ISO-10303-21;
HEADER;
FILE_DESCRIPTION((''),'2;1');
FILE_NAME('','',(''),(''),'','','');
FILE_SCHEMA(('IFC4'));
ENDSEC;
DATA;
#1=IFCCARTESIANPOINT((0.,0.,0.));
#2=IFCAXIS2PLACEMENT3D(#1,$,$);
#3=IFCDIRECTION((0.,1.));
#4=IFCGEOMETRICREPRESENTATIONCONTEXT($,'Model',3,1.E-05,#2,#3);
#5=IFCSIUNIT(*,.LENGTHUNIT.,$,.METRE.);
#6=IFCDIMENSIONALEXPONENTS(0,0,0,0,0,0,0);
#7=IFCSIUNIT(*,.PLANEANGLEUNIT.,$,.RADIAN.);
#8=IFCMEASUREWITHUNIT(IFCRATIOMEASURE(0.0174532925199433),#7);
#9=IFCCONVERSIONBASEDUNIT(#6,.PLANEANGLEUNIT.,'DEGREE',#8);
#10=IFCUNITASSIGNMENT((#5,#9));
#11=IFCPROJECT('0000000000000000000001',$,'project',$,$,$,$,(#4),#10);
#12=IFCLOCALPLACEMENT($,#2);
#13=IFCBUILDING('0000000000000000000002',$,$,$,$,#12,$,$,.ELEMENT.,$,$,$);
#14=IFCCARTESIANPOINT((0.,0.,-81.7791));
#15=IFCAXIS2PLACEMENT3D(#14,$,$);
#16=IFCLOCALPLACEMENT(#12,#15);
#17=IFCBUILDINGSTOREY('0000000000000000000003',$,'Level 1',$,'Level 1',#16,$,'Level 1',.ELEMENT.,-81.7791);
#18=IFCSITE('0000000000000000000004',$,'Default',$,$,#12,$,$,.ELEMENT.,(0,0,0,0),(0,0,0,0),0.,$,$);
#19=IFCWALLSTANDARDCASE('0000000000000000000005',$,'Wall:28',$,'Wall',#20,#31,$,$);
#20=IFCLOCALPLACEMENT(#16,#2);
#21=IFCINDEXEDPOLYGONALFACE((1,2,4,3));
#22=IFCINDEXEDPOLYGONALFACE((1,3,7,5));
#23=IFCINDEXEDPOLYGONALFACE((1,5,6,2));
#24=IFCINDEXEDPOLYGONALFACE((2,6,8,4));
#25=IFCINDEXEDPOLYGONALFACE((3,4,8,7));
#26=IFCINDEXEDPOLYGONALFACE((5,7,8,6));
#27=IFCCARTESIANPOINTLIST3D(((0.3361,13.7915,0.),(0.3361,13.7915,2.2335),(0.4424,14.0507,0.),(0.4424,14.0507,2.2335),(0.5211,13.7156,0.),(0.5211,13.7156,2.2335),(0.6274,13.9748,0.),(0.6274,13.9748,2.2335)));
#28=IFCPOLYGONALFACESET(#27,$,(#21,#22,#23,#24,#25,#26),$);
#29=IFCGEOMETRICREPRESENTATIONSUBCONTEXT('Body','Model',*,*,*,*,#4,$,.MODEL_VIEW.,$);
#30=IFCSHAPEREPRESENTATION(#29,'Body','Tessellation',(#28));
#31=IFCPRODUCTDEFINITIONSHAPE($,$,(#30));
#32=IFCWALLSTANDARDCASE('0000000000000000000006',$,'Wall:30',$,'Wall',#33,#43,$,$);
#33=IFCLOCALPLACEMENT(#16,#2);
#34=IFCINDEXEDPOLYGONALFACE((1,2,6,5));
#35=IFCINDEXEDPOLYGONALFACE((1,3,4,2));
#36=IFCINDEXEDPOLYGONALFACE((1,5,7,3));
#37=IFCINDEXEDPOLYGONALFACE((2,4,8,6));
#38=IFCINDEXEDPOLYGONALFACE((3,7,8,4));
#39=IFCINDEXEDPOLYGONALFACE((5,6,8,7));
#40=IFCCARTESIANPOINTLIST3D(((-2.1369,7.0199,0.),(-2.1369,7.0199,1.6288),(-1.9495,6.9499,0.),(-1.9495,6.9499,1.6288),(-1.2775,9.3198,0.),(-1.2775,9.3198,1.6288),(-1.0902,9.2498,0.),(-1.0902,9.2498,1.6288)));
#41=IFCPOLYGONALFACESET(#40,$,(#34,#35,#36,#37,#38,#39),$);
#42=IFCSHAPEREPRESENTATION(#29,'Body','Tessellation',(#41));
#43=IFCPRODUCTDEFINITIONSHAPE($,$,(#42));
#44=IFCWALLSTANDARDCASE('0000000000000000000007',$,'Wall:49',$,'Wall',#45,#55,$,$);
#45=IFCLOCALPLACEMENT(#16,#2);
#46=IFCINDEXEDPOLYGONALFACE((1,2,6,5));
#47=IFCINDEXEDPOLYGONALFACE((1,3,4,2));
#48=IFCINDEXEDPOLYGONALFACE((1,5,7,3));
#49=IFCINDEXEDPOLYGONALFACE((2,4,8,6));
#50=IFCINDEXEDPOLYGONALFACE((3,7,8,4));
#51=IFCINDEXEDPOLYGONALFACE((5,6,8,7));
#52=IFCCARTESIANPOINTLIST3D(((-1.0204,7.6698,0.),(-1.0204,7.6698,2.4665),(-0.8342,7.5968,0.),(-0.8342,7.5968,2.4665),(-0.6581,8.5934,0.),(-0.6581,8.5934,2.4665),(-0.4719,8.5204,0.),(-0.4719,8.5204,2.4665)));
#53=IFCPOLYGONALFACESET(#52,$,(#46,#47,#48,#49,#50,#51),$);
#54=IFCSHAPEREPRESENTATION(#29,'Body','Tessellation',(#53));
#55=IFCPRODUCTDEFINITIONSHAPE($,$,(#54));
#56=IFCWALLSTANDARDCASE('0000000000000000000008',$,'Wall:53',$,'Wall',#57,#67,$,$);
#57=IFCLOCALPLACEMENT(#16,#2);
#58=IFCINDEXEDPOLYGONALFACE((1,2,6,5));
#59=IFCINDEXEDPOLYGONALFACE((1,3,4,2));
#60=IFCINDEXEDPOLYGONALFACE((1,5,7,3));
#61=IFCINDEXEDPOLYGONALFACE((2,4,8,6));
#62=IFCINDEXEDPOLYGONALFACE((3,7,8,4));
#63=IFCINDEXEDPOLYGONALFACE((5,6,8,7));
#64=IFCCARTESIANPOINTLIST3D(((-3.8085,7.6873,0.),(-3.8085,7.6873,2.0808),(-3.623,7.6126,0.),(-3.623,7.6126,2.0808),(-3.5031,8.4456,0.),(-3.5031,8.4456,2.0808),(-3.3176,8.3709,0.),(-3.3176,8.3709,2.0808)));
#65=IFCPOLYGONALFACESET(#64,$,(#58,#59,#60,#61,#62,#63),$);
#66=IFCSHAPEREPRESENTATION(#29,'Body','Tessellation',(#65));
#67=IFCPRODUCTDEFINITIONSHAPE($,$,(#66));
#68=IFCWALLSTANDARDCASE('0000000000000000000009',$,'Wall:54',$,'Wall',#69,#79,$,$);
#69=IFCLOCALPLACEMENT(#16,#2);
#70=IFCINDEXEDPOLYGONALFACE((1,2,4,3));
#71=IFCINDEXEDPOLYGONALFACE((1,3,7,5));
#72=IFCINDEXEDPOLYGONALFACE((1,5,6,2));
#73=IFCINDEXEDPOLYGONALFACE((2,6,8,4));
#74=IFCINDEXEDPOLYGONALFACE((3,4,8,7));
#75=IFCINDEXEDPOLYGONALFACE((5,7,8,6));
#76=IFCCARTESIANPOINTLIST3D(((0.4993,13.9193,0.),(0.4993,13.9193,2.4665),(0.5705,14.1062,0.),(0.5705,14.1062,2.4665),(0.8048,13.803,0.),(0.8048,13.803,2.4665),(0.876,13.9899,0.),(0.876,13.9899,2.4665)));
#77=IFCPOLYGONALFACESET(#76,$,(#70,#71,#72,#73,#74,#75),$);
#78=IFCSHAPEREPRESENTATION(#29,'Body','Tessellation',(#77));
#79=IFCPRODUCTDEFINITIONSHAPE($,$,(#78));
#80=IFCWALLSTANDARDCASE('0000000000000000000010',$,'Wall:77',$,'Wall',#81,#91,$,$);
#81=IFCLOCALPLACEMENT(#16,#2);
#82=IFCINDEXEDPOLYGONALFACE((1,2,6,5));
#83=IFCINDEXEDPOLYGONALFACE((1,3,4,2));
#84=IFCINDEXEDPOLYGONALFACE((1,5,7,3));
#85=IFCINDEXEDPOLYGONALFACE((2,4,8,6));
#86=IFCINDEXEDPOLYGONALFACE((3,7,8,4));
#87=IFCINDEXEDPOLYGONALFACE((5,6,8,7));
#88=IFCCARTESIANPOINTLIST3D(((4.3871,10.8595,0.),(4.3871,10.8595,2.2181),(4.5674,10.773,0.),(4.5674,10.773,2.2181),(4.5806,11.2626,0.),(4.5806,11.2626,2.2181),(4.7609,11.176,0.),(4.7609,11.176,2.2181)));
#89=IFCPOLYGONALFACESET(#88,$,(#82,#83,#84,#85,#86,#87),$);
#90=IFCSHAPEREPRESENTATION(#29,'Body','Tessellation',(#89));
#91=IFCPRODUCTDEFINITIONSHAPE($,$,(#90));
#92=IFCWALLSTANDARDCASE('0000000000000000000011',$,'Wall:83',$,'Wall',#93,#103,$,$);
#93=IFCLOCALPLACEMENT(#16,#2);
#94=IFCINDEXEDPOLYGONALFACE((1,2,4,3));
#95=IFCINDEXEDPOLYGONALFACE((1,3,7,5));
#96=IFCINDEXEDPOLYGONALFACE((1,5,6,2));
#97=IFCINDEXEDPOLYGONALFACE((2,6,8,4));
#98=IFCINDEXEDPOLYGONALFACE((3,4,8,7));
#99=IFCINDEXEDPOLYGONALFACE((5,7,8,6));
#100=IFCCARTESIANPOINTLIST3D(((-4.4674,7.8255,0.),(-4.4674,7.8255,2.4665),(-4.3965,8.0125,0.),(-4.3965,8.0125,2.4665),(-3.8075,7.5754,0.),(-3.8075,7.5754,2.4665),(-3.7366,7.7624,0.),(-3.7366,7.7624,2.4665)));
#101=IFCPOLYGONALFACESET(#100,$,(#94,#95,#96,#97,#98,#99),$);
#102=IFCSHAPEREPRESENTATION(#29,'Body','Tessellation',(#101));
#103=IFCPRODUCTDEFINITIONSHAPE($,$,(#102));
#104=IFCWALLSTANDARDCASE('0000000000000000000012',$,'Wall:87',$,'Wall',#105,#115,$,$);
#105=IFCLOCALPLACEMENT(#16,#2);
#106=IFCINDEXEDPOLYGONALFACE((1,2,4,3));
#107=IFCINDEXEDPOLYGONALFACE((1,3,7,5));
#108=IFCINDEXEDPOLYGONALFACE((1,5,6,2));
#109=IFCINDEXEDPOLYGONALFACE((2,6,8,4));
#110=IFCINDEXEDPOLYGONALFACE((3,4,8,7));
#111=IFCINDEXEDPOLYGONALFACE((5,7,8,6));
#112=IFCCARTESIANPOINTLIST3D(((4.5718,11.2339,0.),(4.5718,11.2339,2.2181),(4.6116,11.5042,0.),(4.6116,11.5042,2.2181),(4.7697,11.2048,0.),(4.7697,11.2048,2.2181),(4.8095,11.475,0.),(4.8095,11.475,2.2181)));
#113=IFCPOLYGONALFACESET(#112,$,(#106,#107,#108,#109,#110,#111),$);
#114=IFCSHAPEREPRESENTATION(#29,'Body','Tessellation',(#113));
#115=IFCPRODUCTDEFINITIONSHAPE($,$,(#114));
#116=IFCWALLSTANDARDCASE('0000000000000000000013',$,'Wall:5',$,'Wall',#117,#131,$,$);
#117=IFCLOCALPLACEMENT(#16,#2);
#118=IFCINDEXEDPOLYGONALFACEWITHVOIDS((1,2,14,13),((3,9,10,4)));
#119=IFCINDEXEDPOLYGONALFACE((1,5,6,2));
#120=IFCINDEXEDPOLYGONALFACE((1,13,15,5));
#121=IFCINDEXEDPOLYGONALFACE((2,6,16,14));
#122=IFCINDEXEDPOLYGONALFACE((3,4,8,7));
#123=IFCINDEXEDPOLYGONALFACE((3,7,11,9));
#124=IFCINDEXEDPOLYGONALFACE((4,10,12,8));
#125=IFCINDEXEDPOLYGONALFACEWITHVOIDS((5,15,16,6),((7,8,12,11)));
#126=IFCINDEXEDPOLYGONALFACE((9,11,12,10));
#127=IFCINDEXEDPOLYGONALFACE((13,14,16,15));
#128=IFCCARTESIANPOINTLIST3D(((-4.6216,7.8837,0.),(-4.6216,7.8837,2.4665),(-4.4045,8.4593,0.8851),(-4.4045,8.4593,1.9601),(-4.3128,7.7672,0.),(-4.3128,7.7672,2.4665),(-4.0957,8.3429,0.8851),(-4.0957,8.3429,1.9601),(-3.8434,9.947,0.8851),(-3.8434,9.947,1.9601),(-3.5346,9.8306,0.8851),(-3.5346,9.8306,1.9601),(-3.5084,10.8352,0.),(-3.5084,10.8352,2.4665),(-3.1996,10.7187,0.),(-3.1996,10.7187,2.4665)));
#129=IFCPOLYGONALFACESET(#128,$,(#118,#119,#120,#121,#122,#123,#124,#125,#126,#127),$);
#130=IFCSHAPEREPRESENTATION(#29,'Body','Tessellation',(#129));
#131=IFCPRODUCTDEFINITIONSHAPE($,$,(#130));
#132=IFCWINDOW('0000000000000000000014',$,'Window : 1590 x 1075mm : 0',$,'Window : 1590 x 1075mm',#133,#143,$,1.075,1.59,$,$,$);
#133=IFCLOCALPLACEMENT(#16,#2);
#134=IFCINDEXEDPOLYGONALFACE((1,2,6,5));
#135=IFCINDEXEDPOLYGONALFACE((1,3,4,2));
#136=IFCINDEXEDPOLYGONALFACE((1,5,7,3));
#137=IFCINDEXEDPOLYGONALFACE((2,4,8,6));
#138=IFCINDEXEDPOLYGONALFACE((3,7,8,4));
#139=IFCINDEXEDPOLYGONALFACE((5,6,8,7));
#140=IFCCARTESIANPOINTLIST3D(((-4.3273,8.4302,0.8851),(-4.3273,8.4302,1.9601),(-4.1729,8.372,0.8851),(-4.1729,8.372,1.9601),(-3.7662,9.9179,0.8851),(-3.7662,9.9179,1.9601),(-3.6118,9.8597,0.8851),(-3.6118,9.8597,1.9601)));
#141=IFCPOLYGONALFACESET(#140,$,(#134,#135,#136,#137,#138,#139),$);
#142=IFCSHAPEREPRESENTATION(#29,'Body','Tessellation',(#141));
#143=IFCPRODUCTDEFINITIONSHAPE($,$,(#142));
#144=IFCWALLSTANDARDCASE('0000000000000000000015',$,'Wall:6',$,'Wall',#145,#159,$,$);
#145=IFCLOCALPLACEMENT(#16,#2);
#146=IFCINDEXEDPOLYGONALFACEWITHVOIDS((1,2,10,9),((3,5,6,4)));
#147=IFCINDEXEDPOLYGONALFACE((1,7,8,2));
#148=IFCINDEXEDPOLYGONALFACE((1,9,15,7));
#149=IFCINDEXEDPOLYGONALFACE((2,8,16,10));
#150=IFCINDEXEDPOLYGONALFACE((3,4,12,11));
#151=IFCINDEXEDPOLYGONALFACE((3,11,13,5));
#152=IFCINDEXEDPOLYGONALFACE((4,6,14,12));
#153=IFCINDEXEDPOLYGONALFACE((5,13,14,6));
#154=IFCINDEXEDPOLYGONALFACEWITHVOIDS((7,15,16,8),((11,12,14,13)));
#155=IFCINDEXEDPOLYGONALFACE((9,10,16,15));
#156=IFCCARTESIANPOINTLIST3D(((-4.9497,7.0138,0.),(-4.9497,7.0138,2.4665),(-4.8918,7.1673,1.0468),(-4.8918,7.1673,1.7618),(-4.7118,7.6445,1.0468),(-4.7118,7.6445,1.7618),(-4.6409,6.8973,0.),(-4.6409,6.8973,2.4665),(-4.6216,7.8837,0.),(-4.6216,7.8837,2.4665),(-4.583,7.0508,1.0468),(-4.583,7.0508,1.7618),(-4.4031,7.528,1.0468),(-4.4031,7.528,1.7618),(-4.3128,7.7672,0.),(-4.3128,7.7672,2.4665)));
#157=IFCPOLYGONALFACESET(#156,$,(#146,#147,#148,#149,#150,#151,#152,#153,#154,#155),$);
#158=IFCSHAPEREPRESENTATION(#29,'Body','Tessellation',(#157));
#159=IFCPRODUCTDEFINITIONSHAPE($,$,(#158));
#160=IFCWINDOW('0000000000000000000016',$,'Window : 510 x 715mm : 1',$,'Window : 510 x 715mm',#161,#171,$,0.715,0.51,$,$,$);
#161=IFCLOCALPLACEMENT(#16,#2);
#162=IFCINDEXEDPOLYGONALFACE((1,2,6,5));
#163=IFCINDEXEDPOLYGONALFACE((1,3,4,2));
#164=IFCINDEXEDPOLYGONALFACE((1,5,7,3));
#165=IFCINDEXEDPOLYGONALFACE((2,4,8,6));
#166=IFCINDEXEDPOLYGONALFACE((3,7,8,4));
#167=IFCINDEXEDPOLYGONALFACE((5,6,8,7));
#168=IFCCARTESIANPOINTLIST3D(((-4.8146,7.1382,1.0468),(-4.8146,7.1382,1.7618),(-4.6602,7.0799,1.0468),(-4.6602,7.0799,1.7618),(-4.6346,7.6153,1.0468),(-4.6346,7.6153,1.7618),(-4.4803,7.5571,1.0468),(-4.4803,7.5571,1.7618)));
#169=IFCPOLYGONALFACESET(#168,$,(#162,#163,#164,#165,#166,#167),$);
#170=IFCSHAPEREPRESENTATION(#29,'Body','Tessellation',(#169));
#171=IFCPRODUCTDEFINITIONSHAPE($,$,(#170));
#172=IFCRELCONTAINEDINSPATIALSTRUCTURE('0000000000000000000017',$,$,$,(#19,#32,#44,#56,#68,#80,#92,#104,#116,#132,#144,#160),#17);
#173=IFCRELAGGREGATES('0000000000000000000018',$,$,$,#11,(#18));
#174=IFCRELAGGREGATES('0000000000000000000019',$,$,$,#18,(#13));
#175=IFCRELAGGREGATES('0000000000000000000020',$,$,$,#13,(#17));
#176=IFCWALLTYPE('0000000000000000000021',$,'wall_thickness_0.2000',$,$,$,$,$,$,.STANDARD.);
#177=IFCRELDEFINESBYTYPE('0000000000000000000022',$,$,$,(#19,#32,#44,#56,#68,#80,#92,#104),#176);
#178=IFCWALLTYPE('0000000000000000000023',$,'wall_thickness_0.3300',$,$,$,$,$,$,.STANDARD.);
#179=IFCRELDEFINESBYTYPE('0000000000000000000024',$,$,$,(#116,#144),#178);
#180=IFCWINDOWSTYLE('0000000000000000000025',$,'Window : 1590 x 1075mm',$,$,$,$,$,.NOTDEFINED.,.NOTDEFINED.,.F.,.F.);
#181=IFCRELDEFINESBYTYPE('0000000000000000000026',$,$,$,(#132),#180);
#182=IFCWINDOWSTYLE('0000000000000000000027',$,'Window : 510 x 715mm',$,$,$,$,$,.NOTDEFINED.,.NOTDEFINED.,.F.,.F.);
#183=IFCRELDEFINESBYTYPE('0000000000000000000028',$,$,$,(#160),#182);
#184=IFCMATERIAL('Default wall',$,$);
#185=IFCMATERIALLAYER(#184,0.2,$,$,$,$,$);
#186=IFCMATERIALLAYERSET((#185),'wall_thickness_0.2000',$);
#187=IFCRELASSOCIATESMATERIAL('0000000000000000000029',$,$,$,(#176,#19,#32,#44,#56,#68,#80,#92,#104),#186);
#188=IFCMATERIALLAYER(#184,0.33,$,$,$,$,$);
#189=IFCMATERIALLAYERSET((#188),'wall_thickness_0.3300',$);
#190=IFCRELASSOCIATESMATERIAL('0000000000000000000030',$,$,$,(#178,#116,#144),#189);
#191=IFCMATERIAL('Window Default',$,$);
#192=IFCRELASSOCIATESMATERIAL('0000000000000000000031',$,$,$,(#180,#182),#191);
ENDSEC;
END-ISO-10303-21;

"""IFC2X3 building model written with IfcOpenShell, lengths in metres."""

from ifc_helpers import new_model, entity, si_unit, converted_unit, direction, frame, frame_2d, origin, origin_2d_with_axis, place, context, subcontext, project, spatial, polyline, rectangle, outline, extrude, source, transform, mapped, material, layer, layer_set, layer_usage, type_object, type_shapes, element, fill, save


model = new_model("IFC2X3")

# Units and contexts
model_context = context("Model", 3, precision=1e-05, world=origin(), true_north=direction((0.0, 1.0)))
body_context = subcontext(model_context, "Body", "Model", "MODEL_VIEW")
ifc_project = project(units=[si_unit("LENGTHUNIT", "METRE"), converted_unit("PLANEANGLEUNIT", "DEGREE", entity("IfcRatioMeasure", 0.0174532925199433), si_unit("PLANEANGLEUNIT", "RADIAN"), dimensions=[0, 0, 0, 0, 0, 0, 0])], contexts=[model_context])

# Site, building, storey
placement_1 = place(None, origin())
site = spatial("IfcSite", under=ifc_project, at=placement_1, Name="Default", CompositionType="ELEMENT", RefLatitude=(0, 0, 0, 0), RefLongitude=(0, 0, 0, 0), RefElevation=0.0)
building = spatial("IfcBuilding", under=site, at=placement_1, CompositionType="ELEMENT")
storey_placement = place(placement_1, frame((0.0, 0.0, -81.7791)))
storey = spatial("IfcBuildingStorey", under=building, at=storey_placement, Name="Level 1", ObjectType="Level 1", LongName="Level 1", CompositionType="ELEMENT", Elevation=-81.7791)

# Walls
ifc_material_1 = material(Name="Default wall")
ifc_layer_1 = layer(ifc_material_1, 0.2)
ifc_layer_set_1 = layer_set([ifc_layer_1], Name="wall_thickness_0.2000")
ifc_layer_usage_1 = layer_usage(ifc_layer_set_1, "AXIS2", "POSITIVE", -0.1)
wall_type_1 = type_object("IfcWallType", Name="wall_thickness_0.2000", PredefinedType="STANDARD", material=ifc_layer_set_1)
wall_1_placement = place(storey_placement, frame((0.5349, 14.0127, 0.0), z_axis=(0.0, 0.0, 1.0), x_axis=(-0.379483, -0.925199, 0.0)))
element("IfcWallStandardCase", 1, at=wall_1_placement, inside=storey, type_object=wall_type_1, material=ifc_layer_usage_1, Name="Wall:28", ObjectType="Wall", context=body_context, shape_type="SweptSolid", body=[
    extrude(outline(polyline([(0.2802, -0.1), (0.2802, 0.1), (0.0, 0.1), (0.0, -0.1), (0.2802, -0.1)])), origin(), (0.0, 0.0, 1.0), 2.2335),
])
wall_2_placement = place(storey_placement, frame((-1.1839, 9.2848, 0.0), z_axis=(0.0, 0.0, 1.0), x_axis=(-0.350013, -0.936745, 0.0)))
element("IfcWallStandardCase", 2, at=wall_2_placement, inside=storey, type_object=wall_type_1, material=ifc_layer_usage_1, Name="Wall:30", ObjectType="Wall", context=body_context, shape_type="SweptSolid", body=[
    extrude(outline(polyline([(2.4552, -0.1), (2.4552, 0.1), (0.0, 0.1), (0.0, -0.1), (2.4552, -0.1)])), origin(), (0.0, 0.0, 1.0), 1.6288),
])
wall_3_placement = place(storey_placement, frame((-0.565, 8.5569, 0.0), z_axis=(0.0, 0.0, 1.0), x_axis=(-0.365186, -0.930935, 0.0)))
element("IfcWallStandardCase", 3, at=wall_3_placement, inside=storey, type_object=wall_type_1, material=ifc_layer_usage_1, Name="Wall:49", ObjectType="Wall", context=body_context, shape_type="SweptSolid", body=[
    extrude(outline(polyline([(0.9922, -0.1), (0.9922, 0.1), (0.0, 0.1), (0.0, -0.1), (0.9922, -0.1)])), origin(), (0.0, 0.0, 1.0), 2.4665),
])
wall_4_placement = place(storey_placement, frame((-3.4104, 8.4082, 0.0), z_axis=(0.0, 0.0, 1.0), x_axis=(-0.373585, -0.927596, 0.0)))
element("IfcWallStandardCase", 4, at=wall_4_placement, inside=storey, type_object=wall_type_1, material=ifc_layer_usage_1, Name="Wall:53", ObjectType="Wall", context=body_context, shape_type="SweptSolid", body=[
    extrude(outline(polyline([(0.8175, -0.1), (0.8175, 0.1), (0.0, 0.1), (0.0, -0.1), (0.8175, -0.1)])), origin(), (0.0, 0.0, 1.0), 2.0808),
])
wall_5_placement = place(storey_placement, frame((0.8404, 13.8964, 0.0), z_axis=(0.0, 0.0, 1.0), x_axis=(-0.93455, 0.355831, 0.0)))
element("IfcWallStandardCase", 5, at=wall_5_placement, inside=storey, type_object=wall_type_1, material=ifc_layer_usage_1, Name="Wall:54", ObjectType="Wall", context=body_context, shape_type="SweptSolid", body=[
    extrude(outline(polyline([(0.3269, -0.1), (0.3269, 0.1), (0.0, 0.1), (0.0, -0.1), (0.3269, -0.1)])), origin(), (0.0, 0.0, 1.0), 2.4665),
])
wall_6_placement = place(storey_placement, frame((4.6708, 11.2193, 0.0), z_axis=(0.0, 0.0, 1.0), x_axis=(-0.432839, -0.901471, 0.0)))
element("IfcWallStandardCase", 6, at=wall_6_placement, inside=storey, type_object=wall_type_1, material=ifc_layer_usage_1, Name="Wall:77", ObjectType="Wall", context=body_context, shape_type="SweptSolid", body=[
    extrude(outline(polyline([(0.4471, -0.1), (0.4471, 0.1), (0.0, 0.1), (0.0, -0.1), (0.4471, -0.1)])), origin(), (0.0, 0.0, 1.0), 2.2181),
])
wall_7_placement = place(storey_placement, frame((-4.4319, 7.919, 0.0), z_axis=(0.0, 0.0, 1.0), x_axis=(0.935092, -0.354404, 0.0)))
element("IfcWallStandardCase", 7, at=wall_7_placement, inside=storey, type_object=wall_type_1, material=ifc_layer_usage_1, Name="Wall:83", ObjectType="Wall", context=body_context, shape_type="SweptSolid", body=[
    extrude(outline(polyline([(0.7057, -0.1), (0.7057, 0.1), (0.0, 0.1), (0.0, -0.1), (0.7057, -0.1)])), origin(), (0.0, 0.0, 1.0), 2.4665),
])
wall_8_placement = place(storey_placement, frame((4.7105, 11.4896, 0.0), z_axis=(0.0, 0.0, 1.0), x_axis=(-0.145589, -0.989345, 0.0)))
element("IfcWallStandardCase", 8, at=wall_8_placement, inside=storey, type_object=wall_type_1, material=ifc_layer_usage_1, Name="Wall:87", ObjectType="Wall", context=body_context, shape_type="SweptSolid", body=[
    extrude(outline(polyline([(0.2732, -0.1), (0.2732, 0.1), (0.0, 0.1), (0.0, -0.1), (0.2732, -0.1)])), origin(), (0.0, 0.0, 1.0), 2.2181),
])

# Walls, openings, windows
ifc_layer_2 = layer(ifc_material_1, 0.33)
ifc_layer_set_2 = layer_set([ifc_layer_2], Name="wall_thickness_0.3300")
ifc_layer_usage_2 = layer_usage(ifc_layer_set_2, "AXIS2", "POSITIVE", -0.165)
wall_type_2 = type_object("IfcWallType", Name="wall_thickness_0.3300", PredefinedType="STANDARD", material=ifc_layer_set_2)
wall_9_placement = place(storey_placement, frame((-3.354, 10.7769, 0.0), z_axis=(0.0, 0.0, 1.0), x_axis=(-0.352899, -0.935661, 0.0)))
wall_9 = element("IfcWallStandardCase", 9, at=wall_9_placement, inside=storey, type_object=wall_type_2, material=ifc_layer_usage_2, Name="Wall:5", ObjectType="Wall", context=body_context, shape_type="SweptSolid", body=[
    extrude(outline(polyline([(3.1544, -0.165), (3.1544, 0.165), (0.0, 0.165), (0.0, -0.165), (3.1544, -0.165)])), origin(), (0.0, 0.0, 1.0), 2.4665),
])
opening_1_placement = place(wall_9_placement, frame((0.9492, -0.165, 0.8851)))
opening_1 = element("IfcOpeningElement", 10, at=opening_1_placement, cuts=wall_9, ObjectType="Opening", context=body_context, shape_type="SweptSolid", body=[
    extrude(rectangle(XDim=1.59, YDim=1.075, at=frame_2d((0.5375, 0.795), x_axis=(0.0, 1.0))), frame((0.0, 0.0, 0.0), z_axis=(0.0, 1.0, 0.0), x_axis=(0.0, 0.0, 1.0)), (0.0, 0.0, 1.0), 0.33),
])
ifc_material_2 = material(Name="Window Default")
window_style_1 = type_object("IfcWindowStyle", Name="Window : 1590 x 1075mm", ConstructionType="NOTDEFINED", OperationType="NOTDEFINED", ParameterTakesPrecedence=False, Sizeable=False, material=ifc_material_2)
shared_shape_1 = source(origin(), body_context, "Body", "SweptSolid", [
    extrude(rectangle(XDim=0.165, YDim=1.59, at=origin_2d_with_axis()), frame((0.795, 0.165, 0.0), z_axis=(0.0, 0.0, 1.0), x_axis=(0.0, 1.0, 0.0)), (0.0, 0.0, 1.0), 1.075),
])
type_shapes(window_style_1, [shared_shape_1])
window_1_placement = place(opening_1_placement, origin())
window_1 = element("IfcWindow", 11, at=window_1_placement, inside=storey, type_object=window_style_1, Name="Window : 1590 x 1075mm : 0", ObjectType="Window : 1590 x 1075mm", OverallHeight=1.075, OverallWidth=1.59, context=body_context, shape_type="MappedRepresentation", body=[
    mapped(shared_shape_1, transform((0.0, 0.0, 0.0), scale=1.0)),
])
fill(opening_1, window_1)
wall_10_placement = place(storey_placement, frame((-4.4672, 7.8255, 0.0), z_axis=(0.0, 0.0, 1.0), x_axis=(-0.352899, -0.935661, 0.0)))
wall_10 = element("IfcWallStandardCase", 12, at=wall_10_placement, inside=storey, type_object=wall_type_2, material=ifc_layer_usage_2, Name="Wall:6", ObjectType="Wall", context=body_context, shape_type="SweptSolid", body=[
    extrude(outline(polyline([(0.9297, -0.165), (0.9297, 0.165), (0.0, 0.165), (0.0, -0.165), (0.9297, -0.165)])), origin(), (0.0, 0.0, 1.0), 2.4665),
])
opening_2_placement = place(wall_10_placement, frame((0.2557, -0.165, 1.0468)))
opening_2 = element("IfcOpeningElement", 13, at=opening_2_placement, cuts=wall_10, ObjectType="Opening", context=body_context, shape_type="SweptSolid", body=[
    extrude(rectangle(XDim=0.51, YDim=0.715, at=frame_2d((0.3575, 0.255), x_axis=(0.0, 1.0))), frame((0.0, 0.0, 0.0), z_axis=(0.0, 1.0, 0.0), x_axis=(0.0, 0.0, 1.0)), (0.0, 0.0, 1.0), 0.33),
])
window_style_2 = type_object("IfcWindowStyle", Name="Window : 510 x 715mm", ConstructionType="NOTDEFINED", OperationType="NOTDEFINED", ParameterTakesPrecedence=False, Sizeable=False, material=ifc_material_2)
shared_shape_2 = source(origin(), body_context, "Body", "SweptSolid", [
    extrude(rectangle(XDim=0.165, YDim=0.51, at=origin_2d_with_axis()), frame((0.255, 0.165, 0.0), z_axis=(0.0, 0.0, 1.0), x_axis=(0.0, 1.0, 0.0)), (0.0, 0.0, 1.0), 0.715),
])
type_shapes(window_style_2, [shared_shape_2])
window_2_placement = place(opening_2_placement, origin())
window_2 = element("IfcWindow", 14, at=window_2_placement, inside=storey, type_object=window_style_2, Name="Window : 510 x 715mm : 1", ObjectType="Window : 510 x 715mm", OverallHeight=0.715, OverallWidth=0.51, context=body_context, shape_type="MappedRepresentation", body=[
    mapped(shared_shape_2, transform((0.0, 0.0, 0.0), scale=1.0)),
])
fill(opening_2, window_2)

save(model, "model.ifc")
